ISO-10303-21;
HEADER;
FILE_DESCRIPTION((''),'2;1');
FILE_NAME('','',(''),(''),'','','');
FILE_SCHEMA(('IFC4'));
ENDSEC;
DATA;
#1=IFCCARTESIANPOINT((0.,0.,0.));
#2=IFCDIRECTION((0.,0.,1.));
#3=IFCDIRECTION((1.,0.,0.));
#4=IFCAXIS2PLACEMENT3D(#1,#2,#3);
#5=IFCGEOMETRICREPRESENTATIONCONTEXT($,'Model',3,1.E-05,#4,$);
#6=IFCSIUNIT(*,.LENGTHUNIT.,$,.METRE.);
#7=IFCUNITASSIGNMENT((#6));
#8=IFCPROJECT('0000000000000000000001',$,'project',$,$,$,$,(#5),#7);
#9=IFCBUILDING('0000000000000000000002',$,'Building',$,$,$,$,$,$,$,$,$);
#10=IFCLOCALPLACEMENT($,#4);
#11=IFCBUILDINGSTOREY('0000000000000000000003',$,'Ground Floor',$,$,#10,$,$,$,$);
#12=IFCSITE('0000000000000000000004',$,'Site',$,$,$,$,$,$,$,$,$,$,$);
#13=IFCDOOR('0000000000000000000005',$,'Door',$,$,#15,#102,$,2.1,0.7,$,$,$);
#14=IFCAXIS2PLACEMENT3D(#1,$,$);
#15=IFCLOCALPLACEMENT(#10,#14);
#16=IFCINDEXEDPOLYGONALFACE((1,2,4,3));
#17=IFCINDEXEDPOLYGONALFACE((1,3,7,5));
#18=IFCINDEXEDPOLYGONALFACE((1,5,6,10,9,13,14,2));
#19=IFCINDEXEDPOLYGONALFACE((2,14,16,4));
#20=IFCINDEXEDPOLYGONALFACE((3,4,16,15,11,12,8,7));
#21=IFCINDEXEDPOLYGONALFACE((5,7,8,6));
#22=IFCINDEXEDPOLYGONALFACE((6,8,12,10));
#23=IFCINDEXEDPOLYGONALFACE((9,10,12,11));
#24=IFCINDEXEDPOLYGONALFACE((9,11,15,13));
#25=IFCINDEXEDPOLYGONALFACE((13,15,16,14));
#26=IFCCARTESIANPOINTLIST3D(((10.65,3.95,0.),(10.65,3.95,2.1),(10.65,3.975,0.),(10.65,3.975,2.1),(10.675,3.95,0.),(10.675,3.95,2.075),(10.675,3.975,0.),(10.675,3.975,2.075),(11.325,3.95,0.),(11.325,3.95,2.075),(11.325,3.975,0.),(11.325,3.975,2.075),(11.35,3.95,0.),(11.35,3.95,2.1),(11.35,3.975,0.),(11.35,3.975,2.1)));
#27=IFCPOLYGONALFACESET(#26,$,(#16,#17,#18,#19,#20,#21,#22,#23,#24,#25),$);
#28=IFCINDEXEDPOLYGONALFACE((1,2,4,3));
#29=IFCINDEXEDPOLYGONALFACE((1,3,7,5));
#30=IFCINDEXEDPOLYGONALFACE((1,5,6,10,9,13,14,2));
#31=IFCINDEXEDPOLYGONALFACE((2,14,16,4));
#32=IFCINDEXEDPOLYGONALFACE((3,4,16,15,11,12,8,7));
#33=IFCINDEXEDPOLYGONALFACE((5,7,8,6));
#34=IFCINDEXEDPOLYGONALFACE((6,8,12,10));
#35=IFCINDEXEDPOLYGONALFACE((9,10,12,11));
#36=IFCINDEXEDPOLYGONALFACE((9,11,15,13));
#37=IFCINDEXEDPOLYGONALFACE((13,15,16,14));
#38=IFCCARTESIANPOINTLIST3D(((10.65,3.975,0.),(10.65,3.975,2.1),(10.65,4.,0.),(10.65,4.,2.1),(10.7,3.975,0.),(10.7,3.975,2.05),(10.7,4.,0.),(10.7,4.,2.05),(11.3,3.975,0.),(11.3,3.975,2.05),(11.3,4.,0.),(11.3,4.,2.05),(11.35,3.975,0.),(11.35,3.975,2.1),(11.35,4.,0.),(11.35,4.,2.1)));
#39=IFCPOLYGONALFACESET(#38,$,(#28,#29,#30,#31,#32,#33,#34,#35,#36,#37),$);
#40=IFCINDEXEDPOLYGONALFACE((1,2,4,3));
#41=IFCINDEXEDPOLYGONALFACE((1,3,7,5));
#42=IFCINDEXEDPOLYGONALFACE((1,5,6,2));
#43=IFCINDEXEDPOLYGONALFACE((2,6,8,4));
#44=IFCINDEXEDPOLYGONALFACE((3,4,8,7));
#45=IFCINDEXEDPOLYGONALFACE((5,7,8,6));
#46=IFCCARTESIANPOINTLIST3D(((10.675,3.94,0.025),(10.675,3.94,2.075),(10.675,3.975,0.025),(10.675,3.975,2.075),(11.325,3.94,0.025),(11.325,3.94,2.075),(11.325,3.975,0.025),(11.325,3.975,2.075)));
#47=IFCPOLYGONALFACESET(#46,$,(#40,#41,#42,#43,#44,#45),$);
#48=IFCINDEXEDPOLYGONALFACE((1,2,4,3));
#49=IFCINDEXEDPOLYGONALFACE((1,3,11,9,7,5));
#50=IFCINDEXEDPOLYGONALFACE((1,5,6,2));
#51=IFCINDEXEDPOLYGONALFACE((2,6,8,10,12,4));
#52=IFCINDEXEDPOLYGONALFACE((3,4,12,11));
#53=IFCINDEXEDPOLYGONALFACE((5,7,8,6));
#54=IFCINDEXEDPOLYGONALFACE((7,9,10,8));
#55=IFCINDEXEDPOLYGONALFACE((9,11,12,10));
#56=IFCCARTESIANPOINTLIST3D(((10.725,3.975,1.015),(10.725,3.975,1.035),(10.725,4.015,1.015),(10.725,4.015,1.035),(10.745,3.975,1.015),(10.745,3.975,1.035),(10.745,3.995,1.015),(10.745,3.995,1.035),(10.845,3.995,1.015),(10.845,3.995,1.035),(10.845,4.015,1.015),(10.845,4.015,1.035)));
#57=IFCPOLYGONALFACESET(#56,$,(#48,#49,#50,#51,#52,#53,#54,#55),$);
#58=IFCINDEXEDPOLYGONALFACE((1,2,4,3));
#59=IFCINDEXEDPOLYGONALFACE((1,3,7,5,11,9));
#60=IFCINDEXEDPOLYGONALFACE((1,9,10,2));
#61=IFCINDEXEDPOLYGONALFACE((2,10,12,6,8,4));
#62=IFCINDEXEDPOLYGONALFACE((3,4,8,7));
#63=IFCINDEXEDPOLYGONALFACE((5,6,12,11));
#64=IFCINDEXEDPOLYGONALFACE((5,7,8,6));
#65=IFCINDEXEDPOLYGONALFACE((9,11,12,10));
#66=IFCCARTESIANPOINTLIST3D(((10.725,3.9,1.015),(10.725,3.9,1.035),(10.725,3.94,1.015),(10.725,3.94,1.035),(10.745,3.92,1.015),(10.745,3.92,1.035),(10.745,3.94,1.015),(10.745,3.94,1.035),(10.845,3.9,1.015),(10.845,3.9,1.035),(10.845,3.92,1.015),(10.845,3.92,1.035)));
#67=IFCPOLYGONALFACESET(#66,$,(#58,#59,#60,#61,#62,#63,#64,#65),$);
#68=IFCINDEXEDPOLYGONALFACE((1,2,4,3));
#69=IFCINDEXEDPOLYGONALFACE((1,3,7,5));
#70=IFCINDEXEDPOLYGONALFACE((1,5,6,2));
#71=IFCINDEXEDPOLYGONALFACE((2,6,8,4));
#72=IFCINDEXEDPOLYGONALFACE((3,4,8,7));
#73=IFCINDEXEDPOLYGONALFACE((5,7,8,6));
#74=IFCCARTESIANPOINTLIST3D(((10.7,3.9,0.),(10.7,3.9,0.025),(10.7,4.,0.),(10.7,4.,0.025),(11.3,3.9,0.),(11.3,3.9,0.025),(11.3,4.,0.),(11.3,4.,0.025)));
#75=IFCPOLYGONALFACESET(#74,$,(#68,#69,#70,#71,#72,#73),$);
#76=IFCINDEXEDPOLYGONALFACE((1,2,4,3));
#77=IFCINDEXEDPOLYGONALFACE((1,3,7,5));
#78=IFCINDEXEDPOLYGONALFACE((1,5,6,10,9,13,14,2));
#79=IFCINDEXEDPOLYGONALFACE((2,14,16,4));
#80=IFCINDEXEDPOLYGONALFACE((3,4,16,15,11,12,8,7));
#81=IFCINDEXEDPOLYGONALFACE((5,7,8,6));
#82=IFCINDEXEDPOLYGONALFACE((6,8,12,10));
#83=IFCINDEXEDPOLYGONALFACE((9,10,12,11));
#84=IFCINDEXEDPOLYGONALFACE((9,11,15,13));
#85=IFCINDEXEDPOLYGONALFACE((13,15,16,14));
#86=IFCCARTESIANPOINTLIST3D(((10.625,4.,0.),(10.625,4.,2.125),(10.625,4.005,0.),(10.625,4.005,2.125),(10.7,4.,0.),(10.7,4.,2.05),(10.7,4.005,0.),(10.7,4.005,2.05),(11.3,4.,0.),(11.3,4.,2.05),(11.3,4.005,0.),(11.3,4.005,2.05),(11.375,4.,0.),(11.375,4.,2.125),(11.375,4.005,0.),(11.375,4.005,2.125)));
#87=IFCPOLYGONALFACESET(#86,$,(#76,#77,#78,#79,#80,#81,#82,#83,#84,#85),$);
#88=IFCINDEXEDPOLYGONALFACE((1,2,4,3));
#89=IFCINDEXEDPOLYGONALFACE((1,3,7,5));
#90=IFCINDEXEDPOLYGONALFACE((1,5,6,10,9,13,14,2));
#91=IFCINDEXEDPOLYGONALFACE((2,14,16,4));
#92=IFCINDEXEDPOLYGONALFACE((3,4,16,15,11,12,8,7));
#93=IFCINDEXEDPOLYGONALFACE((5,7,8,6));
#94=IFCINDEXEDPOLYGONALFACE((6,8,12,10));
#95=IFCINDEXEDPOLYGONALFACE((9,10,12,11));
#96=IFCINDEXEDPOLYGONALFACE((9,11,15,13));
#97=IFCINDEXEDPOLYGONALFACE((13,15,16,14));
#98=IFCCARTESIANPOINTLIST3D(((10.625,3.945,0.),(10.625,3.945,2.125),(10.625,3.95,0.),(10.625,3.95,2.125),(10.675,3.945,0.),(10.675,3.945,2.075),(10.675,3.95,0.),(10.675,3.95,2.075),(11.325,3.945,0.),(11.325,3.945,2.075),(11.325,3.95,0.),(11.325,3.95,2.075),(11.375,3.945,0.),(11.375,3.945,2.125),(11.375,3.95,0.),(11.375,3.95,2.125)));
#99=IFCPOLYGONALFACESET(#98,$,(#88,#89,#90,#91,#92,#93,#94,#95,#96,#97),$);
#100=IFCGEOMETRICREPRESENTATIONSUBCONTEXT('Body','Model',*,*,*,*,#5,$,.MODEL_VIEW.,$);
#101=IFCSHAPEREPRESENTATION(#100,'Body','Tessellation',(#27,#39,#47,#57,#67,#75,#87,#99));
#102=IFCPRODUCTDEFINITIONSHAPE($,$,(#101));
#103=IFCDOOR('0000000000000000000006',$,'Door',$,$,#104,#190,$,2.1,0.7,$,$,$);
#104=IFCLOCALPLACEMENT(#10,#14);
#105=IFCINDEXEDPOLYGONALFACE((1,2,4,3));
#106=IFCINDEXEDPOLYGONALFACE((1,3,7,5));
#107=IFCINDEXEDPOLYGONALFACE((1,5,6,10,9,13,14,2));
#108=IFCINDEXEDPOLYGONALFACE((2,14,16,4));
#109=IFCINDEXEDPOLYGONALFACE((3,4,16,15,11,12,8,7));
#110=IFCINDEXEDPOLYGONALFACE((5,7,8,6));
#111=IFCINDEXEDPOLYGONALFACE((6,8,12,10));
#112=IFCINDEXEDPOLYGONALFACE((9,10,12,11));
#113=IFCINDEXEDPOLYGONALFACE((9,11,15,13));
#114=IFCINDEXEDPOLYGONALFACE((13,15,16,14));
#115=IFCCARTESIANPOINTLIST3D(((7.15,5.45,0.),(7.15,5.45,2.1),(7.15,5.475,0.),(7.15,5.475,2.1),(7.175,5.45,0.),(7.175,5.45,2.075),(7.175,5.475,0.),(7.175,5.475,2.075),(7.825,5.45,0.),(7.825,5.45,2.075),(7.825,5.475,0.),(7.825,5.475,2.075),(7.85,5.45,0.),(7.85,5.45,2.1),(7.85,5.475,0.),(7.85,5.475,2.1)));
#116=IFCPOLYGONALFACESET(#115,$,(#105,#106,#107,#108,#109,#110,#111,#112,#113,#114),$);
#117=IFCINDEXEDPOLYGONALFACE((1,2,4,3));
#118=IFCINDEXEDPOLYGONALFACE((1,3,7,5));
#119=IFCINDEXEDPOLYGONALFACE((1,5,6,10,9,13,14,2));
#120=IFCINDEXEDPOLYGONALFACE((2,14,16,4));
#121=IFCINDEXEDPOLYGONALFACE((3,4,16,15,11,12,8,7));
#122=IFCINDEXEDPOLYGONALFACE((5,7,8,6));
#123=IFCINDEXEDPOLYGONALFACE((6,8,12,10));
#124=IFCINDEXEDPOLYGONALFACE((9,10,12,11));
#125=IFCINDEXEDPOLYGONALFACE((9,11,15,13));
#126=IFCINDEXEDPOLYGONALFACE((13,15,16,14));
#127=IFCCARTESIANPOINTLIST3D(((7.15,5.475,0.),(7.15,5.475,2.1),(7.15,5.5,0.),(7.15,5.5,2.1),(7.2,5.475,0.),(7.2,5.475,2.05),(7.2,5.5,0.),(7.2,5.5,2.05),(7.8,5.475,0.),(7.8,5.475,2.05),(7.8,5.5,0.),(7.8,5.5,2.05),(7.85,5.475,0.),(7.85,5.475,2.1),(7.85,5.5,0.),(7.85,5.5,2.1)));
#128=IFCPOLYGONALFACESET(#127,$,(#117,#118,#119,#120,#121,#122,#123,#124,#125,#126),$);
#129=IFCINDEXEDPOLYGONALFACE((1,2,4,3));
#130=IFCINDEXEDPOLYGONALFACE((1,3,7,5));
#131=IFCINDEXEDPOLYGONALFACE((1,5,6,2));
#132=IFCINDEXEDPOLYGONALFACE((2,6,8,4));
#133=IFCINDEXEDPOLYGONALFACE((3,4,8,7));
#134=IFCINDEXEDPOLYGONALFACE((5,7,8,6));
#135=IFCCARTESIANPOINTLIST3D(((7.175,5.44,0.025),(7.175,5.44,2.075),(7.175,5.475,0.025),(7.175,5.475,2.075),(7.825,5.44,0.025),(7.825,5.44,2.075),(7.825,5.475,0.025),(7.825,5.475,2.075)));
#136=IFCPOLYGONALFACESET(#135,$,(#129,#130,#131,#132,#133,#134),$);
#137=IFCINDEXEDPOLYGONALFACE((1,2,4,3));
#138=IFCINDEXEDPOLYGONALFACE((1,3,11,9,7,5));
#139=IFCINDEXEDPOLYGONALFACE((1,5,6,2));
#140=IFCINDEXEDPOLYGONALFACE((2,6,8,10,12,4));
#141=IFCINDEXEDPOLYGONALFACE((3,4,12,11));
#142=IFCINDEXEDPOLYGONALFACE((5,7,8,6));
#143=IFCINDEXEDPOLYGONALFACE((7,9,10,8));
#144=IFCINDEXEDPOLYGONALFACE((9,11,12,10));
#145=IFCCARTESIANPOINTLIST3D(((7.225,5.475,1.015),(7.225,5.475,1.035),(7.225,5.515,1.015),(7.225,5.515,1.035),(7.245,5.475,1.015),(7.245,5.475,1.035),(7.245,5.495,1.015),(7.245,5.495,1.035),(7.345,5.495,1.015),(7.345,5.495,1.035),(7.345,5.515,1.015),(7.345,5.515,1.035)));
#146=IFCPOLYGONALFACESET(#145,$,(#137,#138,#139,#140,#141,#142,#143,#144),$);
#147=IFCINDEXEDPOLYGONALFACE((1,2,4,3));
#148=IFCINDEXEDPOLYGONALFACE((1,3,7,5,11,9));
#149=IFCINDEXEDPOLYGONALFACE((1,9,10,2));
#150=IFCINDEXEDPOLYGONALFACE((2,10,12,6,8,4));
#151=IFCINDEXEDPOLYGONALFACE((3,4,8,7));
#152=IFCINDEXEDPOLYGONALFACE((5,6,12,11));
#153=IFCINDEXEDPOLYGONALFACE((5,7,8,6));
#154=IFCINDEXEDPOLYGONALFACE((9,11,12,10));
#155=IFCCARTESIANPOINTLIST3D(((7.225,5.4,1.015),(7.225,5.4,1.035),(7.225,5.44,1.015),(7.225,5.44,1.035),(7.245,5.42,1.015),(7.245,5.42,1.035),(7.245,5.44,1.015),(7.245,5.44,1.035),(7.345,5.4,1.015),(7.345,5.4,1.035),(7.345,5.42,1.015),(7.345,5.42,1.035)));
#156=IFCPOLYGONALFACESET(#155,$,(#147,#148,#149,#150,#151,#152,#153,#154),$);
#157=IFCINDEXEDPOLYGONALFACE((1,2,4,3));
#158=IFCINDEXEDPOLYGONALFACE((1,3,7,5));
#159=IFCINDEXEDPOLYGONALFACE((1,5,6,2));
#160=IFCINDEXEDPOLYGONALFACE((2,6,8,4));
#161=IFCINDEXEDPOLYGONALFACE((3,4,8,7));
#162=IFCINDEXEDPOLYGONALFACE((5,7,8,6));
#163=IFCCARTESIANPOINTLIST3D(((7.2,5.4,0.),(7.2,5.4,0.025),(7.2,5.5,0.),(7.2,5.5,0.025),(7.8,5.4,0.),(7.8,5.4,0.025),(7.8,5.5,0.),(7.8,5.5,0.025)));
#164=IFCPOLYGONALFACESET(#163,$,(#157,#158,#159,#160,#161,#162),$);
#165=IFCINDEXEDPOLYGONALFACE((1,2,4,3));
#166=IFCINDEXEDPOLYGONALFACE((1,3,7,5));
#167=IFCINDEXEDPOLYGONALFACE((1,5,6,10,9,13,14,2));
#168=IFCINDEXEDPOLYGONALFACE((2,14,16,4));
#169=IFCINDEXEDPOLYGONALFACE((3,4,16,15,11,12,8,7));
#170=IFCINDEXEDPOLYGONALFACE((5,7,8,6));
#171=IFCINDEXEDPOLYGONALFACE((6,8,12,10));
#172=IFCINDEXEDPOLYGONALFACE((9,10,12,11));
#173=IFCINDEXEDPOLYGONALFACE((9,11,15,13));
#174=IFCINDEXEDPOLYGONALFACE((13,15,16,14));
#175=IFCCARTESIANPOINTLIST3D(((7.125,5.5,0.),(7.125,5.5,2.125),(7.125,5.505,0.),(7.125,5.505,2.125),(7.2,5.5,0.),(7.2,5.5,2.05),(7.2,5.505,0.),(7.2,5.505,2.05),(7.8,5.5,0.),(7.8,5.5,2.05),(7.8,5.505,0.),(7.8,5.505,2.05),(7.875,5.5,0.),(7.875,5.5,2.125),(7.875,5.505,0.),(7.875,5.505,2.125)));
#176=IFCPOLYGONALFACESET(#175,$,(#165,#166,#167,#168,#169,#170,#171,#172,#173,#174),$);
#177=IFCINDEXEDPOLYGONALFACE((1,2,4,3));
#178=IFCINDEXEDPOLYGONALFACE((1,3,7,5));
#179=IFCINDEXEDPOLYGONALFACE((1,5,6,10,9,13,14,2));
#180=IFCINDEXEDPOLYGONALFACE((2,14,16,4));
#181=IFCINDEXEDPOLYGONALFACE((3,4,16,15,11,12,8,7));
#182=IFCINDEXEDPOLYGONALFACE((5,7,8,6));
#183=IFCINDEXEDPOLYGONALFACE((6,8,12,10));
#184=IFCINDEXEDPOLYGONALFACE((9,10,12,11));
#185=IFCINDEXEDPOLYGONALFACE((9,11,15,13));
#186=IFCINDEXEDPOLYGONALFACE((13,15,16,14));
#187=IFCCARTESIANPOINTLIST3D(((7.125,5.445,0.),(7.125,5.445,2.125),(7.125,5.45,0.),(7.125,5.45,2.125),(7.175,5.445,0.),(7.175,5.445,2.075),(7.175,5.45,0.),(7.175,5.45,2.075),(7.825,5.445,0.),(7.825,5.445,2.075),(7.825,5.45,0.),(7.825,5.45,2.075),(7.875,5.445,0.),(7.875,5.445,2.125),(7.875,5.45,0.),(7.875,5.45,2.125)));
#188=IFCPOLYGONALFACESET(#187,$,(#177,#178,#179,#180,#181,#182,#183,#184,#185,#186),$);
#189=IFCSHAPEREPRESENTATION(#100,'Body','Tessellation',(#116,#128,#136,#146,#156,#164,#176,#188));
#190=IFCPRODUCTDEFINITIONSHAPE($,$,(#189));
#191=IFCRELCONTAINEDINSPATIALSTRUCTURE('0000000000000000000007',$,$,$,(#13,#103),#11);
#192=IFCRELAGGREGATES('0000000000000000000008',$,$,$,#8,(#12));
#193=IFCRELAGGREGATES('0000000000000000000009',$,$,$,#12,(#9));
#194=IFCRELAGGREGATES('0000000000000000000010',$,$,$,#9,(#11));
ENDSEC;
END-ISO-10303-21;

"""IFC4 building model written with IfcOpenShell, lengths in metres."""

from ifc_helpers import new_model, si_unit, frame, origin_with_axes, place, context, subcontext, project, spatial, line, indexed_curve, outline, extrude, element, save


model = new_model("IFC4")

# Units and contexts
model_context = context("Model", 3, precision=1e-05, world=origin_with_axes())
body_context = subcontext(model_context, "Body", "Model", "MODEL_VIEW")
ifc_project = project(units=[si_unit("LENGTHUNIT", "METRE")], contexts=[model_context])

# Site, building, storey
site = spatial("IfcSite", under=ifc_project, Name="Site")
building = spatial("IfcBuilding", under=site, Name="Building")
storey_placement = place(None, origin_with_axes())
storey = spatial("IfcBuildingStorey", under=building, at=storey_placement, Name="Ground Floor")

# Doors
door_1_placement = place(storey_placement, frame((11.35, 4.0, 0.0), z_axis=(0.0, 0.0, 1.0), x_axis=(-1.0, 0.0, 0.0)))
element("IfcDoor", 1, at=door_1_placement, inside=storey, Name="Door", OverallHeight=2.1, OverallWidth=0.7, context=body_context, shape_type="SweptSolid", body=[
    extrude(outline(indexed_curve([(0.0, 0.0), (0.0, 2.1), (0.7, 2.1), (0.7, 0.0), (0.675, 0.0), (0.675, 2.075), (0.025, 2.075), (0.025, 0.0)], segments=[line(1, 2, 3, 4, 5, 6, 7, 8, 1)])), frame((0.0, 0.025, 0.0), z_axis=(0.0, -1.0, 0.0), x_axis=(1.0, 0.0, 0.0)), (0.0, 0.0, -1.0), 0.025),
    extrude(outline(indexed_curve([(0.0, 0.0), (0.0, 2.1), (0.7, 2.1), (0.7, 0.0), (0.65, 0.0), (0.65, 2.05), (0.05, 2.05), (0.05, 0.0)], segments=[line(1, 2, 3, 4, 5, 6, 7, 8, 1)])), frame((0.0, 0.0, 0.0), z_axis=(0.0, -1.0, 0.0), x_axis=(1.0, 0.0, 0.0)), (0.0, 0.0, -1.0), 0.025),
    extrude(outline(indexed_curve([(0.0, 0.0), (0.65, 0.0), (0.65, 0.035), (0.0, 0.035)], segments=[line(1, 2, 3, 4, 1)])), frame((0.025, 0.025, 0.025), z_axis=(0.0, 0.0, 1.0), x_axis=(1.0, 0.0, 0.0)), (0.0, 0.0, 1.0), 2.05),
    extrude(outline(indexed_curve([(0.0, 0.0), (0.0, -0.04), (-0.12, -0.04), (-0.12, -0.02), (-0.02, -0.02), (-0.02, 0.0)], segments=[line(1, 2, 3, 4, 5, 6, 1)])), frame((0.625, 0.025, 1.015), z_axis=(0.0, 0.0, 1.0), x_axis=(1.0, 0.0, 0.0)), (0.0, 0.0, 1.0), 0.02),
    extrude(outline(indexed_curve([(0.0, 0.0), (0.0, 0.04), (-0.12, 0.04), (-0.12, 0.02), (-0.02, 0.02), (-0.02, 0.0)], segments=[line(1, 2, 3, 4, 5, 6, 1)])), frame((0.625, 0.06, 1.015), z_axis=(0.0, 0.0, 1.0), x_axis=(1.0, 0.0, 0.0)), (0.0, 0.0, 1.0), 0.02),
    extrude(outline(indexed_curve([(0.0, 0.0), (0.6, 0.0), (0.6, 0.1), (0.0, 0.1)], segments=[line(1, 2, 3, 4, 1)])), frame((0.05, 0.0, 0.0), z_axis=(0.0, 0.0, 1.0), x_axis=(1.0, 0.0, 0.0)), (0.0, 0.0, 1.0), 0.025),
    extrude(outline(indexed_curve([(0.0, 0.0), (0.0, 2.125), (0.75, 2.125), (0.75, 0.0), (0.675, 0.0), (0.675, 2.05), (0.075, 2.05), (0.075, 0.0)], segments=[line(1, 2, 3, 4, 5, 6, 7, 8, 1)])), frame((-0.025, -0.005, 0.0), z_axis=(0.0, -1.0, 0.0), x_axis=(1.0, 0.0, 0.0)), (0.0, 0.0, -1.0), 0.005),
    extrude(outline(indexed_curve([(0.0, 0.0), (0.0, 2.125), (0.75, 2.125), (0.75, 0.0), (0.7, 0.0), (0.7, 2.075), (0.05, 2.075), (0.05, 0.0)], segments=[line(1, 2, 3, 4, 5, 6, 7, 8, 1)])), frame((-0.025, 0.05, 0.0), z_axis=(0.0, -1.0, 0.0), x_axis=(1.0, 0.0, 0.0)), (0.0, 0.0, -1.0), 0.005),
])
door_2_placement = place(storey_placement, frame((7.85, 5.5, 0.0), z_axis=(0.0, 0.0, 1.0), x_axis=(-1.0, 0.0, 0.0)))
element("IfcDoor", 2, at=door_2_placement, inside=storey, Name="Door", OverallHeight=2.1, OverallWidth=0.7, context=body_context, shape_type="SweptSolid", body=[
    extrude(outline(indexed_curve([(0.0, 0.0), (0.0, 2.1), (0.7, 2.1), (0.7, 0.0), (0.675, 0.0), (0.675, 2.075), (0.025, 2.075), (0.025, 0.0)], segments=[line(1, 2, 3, 4, 5, 6, 7, 8, 1)])), frame((0.0, 0.025, 0.0), z_axis=(0.0, -1.0, 0.0), x_axis=(1.0, 0.0, 0.0)), (0.0, 0.0, -1.0), 0.025),
    extrude(outline(indexed_curve([(0.0, 0.0), (0.0, 2.1), (0.7, 2.1), (0.7, 0.0), (0.65, 0.0), (0.65, 2.05), (0.05, 2.05), (0.05, 0.0)], segments=[line(1, 2, 3, 4, 5, 6, 7, 8, 1)])), frame((0.0, 0.0, 0.0), z_axis=(0.0, -1.0, 0.0), x_axis=(1.0, 0.0, 0.0)), (0.0, 0.0, -1.0), 0.025),
    extrude(outline(indexed_curve([(0.0, 0.0), (0.65, 0.0), (0.65, 0.035), (0.0, 0.035)], segments=[line(1, 2, 3, 4, 1)])), frame((0.025, 0.025, 0.025), z_axis=(0.0, 0.0, 1.0), x_axis=(1.0, 0.0, 0.0)), (0.0, 0.0, 1.0), 2.05),
    extrude(outline(indexed_curve([(0.0, 0.0), (0.0, -0.04), (-0.12, -0.04), (-0.12, -0.02), (-0.02, -0.02), (-0.02, 0.0)], segments=[line(1, 2, 3, 4, 5, 6, 1)])), frame((0.625, 0.025, 1.015), z_axis=(0.0, 0.0, 1.0), x_axis=(1.0, 0.0, 0.0)), (0.0, 0.0, 1.0), 0.02),
    extrude(outline(indexed_curve([(0.0, 0.0), (0.0, 0.04), (-0.12, 0.04), (-0.12, 0.02), (-0.02, 0.02), (-0.02, 0.0)], segments=[line(1, 2, 3, 4, 5, 6, 1)])), frame((0.625, 0.06, 1.015), z_axis=(0.0, 0.0, 1.0), x_axis=(1.0, 0.0, 0.0)), (0.0, 0.0, 1.0), 0.02),
    extrude(outline(indexed_curve([(0.0, 0.0), (0.6, 0.0), (0.6, 0.1), (0.0, 0.1)], segments=[line(1, 2, 3, 4, 1)])), frame((0.05, 0.0, 0.0), z_axis=(0.0, 0.0, 1.0), x_axis=(1.0, 0.0, 0.0)), (0.0, 0.0, 1.0), 0.025),
    extrude(outline(indexed_curve([(0.0, 0.0), (0.0, 2.125), (0.75, 2.125), (0.75, 0.0), (0.675, 0.0), (0.675, 2.05), (0.075, 2.05), (0.075, 0.0)], segments=[line(1, 2, 3, 4, 5, 6, 7, 8, 1)])), frame((-0.025, -0.005, 0.0), z_axis=(0.0, -1.0, 0.0), x_axis=(1.0, 0.0, 0.0)), (0.0, 0.0, -1.0), 0.005),
    extrude(outline(indexed_curve([(0.0, 0.0), (0.0, 2.125), (0.75, 2.125), (0.75, 0.0), (0.7, 0.0), (0.7, 2.075), (0.05, 2.075), (0.05, 0.0)], segments=[line(1, 2, 3, 4, 5, 6, 7, 8, 1)])), frame((-0.025, 0.05, 0.0), z_axis=(0.0, -1.0, 0.0), x_axis=(1.0, 0.0, 0.0)), (0.0, 0.0, -1.0), 0.005),
])

save(model, "model.ifc")
